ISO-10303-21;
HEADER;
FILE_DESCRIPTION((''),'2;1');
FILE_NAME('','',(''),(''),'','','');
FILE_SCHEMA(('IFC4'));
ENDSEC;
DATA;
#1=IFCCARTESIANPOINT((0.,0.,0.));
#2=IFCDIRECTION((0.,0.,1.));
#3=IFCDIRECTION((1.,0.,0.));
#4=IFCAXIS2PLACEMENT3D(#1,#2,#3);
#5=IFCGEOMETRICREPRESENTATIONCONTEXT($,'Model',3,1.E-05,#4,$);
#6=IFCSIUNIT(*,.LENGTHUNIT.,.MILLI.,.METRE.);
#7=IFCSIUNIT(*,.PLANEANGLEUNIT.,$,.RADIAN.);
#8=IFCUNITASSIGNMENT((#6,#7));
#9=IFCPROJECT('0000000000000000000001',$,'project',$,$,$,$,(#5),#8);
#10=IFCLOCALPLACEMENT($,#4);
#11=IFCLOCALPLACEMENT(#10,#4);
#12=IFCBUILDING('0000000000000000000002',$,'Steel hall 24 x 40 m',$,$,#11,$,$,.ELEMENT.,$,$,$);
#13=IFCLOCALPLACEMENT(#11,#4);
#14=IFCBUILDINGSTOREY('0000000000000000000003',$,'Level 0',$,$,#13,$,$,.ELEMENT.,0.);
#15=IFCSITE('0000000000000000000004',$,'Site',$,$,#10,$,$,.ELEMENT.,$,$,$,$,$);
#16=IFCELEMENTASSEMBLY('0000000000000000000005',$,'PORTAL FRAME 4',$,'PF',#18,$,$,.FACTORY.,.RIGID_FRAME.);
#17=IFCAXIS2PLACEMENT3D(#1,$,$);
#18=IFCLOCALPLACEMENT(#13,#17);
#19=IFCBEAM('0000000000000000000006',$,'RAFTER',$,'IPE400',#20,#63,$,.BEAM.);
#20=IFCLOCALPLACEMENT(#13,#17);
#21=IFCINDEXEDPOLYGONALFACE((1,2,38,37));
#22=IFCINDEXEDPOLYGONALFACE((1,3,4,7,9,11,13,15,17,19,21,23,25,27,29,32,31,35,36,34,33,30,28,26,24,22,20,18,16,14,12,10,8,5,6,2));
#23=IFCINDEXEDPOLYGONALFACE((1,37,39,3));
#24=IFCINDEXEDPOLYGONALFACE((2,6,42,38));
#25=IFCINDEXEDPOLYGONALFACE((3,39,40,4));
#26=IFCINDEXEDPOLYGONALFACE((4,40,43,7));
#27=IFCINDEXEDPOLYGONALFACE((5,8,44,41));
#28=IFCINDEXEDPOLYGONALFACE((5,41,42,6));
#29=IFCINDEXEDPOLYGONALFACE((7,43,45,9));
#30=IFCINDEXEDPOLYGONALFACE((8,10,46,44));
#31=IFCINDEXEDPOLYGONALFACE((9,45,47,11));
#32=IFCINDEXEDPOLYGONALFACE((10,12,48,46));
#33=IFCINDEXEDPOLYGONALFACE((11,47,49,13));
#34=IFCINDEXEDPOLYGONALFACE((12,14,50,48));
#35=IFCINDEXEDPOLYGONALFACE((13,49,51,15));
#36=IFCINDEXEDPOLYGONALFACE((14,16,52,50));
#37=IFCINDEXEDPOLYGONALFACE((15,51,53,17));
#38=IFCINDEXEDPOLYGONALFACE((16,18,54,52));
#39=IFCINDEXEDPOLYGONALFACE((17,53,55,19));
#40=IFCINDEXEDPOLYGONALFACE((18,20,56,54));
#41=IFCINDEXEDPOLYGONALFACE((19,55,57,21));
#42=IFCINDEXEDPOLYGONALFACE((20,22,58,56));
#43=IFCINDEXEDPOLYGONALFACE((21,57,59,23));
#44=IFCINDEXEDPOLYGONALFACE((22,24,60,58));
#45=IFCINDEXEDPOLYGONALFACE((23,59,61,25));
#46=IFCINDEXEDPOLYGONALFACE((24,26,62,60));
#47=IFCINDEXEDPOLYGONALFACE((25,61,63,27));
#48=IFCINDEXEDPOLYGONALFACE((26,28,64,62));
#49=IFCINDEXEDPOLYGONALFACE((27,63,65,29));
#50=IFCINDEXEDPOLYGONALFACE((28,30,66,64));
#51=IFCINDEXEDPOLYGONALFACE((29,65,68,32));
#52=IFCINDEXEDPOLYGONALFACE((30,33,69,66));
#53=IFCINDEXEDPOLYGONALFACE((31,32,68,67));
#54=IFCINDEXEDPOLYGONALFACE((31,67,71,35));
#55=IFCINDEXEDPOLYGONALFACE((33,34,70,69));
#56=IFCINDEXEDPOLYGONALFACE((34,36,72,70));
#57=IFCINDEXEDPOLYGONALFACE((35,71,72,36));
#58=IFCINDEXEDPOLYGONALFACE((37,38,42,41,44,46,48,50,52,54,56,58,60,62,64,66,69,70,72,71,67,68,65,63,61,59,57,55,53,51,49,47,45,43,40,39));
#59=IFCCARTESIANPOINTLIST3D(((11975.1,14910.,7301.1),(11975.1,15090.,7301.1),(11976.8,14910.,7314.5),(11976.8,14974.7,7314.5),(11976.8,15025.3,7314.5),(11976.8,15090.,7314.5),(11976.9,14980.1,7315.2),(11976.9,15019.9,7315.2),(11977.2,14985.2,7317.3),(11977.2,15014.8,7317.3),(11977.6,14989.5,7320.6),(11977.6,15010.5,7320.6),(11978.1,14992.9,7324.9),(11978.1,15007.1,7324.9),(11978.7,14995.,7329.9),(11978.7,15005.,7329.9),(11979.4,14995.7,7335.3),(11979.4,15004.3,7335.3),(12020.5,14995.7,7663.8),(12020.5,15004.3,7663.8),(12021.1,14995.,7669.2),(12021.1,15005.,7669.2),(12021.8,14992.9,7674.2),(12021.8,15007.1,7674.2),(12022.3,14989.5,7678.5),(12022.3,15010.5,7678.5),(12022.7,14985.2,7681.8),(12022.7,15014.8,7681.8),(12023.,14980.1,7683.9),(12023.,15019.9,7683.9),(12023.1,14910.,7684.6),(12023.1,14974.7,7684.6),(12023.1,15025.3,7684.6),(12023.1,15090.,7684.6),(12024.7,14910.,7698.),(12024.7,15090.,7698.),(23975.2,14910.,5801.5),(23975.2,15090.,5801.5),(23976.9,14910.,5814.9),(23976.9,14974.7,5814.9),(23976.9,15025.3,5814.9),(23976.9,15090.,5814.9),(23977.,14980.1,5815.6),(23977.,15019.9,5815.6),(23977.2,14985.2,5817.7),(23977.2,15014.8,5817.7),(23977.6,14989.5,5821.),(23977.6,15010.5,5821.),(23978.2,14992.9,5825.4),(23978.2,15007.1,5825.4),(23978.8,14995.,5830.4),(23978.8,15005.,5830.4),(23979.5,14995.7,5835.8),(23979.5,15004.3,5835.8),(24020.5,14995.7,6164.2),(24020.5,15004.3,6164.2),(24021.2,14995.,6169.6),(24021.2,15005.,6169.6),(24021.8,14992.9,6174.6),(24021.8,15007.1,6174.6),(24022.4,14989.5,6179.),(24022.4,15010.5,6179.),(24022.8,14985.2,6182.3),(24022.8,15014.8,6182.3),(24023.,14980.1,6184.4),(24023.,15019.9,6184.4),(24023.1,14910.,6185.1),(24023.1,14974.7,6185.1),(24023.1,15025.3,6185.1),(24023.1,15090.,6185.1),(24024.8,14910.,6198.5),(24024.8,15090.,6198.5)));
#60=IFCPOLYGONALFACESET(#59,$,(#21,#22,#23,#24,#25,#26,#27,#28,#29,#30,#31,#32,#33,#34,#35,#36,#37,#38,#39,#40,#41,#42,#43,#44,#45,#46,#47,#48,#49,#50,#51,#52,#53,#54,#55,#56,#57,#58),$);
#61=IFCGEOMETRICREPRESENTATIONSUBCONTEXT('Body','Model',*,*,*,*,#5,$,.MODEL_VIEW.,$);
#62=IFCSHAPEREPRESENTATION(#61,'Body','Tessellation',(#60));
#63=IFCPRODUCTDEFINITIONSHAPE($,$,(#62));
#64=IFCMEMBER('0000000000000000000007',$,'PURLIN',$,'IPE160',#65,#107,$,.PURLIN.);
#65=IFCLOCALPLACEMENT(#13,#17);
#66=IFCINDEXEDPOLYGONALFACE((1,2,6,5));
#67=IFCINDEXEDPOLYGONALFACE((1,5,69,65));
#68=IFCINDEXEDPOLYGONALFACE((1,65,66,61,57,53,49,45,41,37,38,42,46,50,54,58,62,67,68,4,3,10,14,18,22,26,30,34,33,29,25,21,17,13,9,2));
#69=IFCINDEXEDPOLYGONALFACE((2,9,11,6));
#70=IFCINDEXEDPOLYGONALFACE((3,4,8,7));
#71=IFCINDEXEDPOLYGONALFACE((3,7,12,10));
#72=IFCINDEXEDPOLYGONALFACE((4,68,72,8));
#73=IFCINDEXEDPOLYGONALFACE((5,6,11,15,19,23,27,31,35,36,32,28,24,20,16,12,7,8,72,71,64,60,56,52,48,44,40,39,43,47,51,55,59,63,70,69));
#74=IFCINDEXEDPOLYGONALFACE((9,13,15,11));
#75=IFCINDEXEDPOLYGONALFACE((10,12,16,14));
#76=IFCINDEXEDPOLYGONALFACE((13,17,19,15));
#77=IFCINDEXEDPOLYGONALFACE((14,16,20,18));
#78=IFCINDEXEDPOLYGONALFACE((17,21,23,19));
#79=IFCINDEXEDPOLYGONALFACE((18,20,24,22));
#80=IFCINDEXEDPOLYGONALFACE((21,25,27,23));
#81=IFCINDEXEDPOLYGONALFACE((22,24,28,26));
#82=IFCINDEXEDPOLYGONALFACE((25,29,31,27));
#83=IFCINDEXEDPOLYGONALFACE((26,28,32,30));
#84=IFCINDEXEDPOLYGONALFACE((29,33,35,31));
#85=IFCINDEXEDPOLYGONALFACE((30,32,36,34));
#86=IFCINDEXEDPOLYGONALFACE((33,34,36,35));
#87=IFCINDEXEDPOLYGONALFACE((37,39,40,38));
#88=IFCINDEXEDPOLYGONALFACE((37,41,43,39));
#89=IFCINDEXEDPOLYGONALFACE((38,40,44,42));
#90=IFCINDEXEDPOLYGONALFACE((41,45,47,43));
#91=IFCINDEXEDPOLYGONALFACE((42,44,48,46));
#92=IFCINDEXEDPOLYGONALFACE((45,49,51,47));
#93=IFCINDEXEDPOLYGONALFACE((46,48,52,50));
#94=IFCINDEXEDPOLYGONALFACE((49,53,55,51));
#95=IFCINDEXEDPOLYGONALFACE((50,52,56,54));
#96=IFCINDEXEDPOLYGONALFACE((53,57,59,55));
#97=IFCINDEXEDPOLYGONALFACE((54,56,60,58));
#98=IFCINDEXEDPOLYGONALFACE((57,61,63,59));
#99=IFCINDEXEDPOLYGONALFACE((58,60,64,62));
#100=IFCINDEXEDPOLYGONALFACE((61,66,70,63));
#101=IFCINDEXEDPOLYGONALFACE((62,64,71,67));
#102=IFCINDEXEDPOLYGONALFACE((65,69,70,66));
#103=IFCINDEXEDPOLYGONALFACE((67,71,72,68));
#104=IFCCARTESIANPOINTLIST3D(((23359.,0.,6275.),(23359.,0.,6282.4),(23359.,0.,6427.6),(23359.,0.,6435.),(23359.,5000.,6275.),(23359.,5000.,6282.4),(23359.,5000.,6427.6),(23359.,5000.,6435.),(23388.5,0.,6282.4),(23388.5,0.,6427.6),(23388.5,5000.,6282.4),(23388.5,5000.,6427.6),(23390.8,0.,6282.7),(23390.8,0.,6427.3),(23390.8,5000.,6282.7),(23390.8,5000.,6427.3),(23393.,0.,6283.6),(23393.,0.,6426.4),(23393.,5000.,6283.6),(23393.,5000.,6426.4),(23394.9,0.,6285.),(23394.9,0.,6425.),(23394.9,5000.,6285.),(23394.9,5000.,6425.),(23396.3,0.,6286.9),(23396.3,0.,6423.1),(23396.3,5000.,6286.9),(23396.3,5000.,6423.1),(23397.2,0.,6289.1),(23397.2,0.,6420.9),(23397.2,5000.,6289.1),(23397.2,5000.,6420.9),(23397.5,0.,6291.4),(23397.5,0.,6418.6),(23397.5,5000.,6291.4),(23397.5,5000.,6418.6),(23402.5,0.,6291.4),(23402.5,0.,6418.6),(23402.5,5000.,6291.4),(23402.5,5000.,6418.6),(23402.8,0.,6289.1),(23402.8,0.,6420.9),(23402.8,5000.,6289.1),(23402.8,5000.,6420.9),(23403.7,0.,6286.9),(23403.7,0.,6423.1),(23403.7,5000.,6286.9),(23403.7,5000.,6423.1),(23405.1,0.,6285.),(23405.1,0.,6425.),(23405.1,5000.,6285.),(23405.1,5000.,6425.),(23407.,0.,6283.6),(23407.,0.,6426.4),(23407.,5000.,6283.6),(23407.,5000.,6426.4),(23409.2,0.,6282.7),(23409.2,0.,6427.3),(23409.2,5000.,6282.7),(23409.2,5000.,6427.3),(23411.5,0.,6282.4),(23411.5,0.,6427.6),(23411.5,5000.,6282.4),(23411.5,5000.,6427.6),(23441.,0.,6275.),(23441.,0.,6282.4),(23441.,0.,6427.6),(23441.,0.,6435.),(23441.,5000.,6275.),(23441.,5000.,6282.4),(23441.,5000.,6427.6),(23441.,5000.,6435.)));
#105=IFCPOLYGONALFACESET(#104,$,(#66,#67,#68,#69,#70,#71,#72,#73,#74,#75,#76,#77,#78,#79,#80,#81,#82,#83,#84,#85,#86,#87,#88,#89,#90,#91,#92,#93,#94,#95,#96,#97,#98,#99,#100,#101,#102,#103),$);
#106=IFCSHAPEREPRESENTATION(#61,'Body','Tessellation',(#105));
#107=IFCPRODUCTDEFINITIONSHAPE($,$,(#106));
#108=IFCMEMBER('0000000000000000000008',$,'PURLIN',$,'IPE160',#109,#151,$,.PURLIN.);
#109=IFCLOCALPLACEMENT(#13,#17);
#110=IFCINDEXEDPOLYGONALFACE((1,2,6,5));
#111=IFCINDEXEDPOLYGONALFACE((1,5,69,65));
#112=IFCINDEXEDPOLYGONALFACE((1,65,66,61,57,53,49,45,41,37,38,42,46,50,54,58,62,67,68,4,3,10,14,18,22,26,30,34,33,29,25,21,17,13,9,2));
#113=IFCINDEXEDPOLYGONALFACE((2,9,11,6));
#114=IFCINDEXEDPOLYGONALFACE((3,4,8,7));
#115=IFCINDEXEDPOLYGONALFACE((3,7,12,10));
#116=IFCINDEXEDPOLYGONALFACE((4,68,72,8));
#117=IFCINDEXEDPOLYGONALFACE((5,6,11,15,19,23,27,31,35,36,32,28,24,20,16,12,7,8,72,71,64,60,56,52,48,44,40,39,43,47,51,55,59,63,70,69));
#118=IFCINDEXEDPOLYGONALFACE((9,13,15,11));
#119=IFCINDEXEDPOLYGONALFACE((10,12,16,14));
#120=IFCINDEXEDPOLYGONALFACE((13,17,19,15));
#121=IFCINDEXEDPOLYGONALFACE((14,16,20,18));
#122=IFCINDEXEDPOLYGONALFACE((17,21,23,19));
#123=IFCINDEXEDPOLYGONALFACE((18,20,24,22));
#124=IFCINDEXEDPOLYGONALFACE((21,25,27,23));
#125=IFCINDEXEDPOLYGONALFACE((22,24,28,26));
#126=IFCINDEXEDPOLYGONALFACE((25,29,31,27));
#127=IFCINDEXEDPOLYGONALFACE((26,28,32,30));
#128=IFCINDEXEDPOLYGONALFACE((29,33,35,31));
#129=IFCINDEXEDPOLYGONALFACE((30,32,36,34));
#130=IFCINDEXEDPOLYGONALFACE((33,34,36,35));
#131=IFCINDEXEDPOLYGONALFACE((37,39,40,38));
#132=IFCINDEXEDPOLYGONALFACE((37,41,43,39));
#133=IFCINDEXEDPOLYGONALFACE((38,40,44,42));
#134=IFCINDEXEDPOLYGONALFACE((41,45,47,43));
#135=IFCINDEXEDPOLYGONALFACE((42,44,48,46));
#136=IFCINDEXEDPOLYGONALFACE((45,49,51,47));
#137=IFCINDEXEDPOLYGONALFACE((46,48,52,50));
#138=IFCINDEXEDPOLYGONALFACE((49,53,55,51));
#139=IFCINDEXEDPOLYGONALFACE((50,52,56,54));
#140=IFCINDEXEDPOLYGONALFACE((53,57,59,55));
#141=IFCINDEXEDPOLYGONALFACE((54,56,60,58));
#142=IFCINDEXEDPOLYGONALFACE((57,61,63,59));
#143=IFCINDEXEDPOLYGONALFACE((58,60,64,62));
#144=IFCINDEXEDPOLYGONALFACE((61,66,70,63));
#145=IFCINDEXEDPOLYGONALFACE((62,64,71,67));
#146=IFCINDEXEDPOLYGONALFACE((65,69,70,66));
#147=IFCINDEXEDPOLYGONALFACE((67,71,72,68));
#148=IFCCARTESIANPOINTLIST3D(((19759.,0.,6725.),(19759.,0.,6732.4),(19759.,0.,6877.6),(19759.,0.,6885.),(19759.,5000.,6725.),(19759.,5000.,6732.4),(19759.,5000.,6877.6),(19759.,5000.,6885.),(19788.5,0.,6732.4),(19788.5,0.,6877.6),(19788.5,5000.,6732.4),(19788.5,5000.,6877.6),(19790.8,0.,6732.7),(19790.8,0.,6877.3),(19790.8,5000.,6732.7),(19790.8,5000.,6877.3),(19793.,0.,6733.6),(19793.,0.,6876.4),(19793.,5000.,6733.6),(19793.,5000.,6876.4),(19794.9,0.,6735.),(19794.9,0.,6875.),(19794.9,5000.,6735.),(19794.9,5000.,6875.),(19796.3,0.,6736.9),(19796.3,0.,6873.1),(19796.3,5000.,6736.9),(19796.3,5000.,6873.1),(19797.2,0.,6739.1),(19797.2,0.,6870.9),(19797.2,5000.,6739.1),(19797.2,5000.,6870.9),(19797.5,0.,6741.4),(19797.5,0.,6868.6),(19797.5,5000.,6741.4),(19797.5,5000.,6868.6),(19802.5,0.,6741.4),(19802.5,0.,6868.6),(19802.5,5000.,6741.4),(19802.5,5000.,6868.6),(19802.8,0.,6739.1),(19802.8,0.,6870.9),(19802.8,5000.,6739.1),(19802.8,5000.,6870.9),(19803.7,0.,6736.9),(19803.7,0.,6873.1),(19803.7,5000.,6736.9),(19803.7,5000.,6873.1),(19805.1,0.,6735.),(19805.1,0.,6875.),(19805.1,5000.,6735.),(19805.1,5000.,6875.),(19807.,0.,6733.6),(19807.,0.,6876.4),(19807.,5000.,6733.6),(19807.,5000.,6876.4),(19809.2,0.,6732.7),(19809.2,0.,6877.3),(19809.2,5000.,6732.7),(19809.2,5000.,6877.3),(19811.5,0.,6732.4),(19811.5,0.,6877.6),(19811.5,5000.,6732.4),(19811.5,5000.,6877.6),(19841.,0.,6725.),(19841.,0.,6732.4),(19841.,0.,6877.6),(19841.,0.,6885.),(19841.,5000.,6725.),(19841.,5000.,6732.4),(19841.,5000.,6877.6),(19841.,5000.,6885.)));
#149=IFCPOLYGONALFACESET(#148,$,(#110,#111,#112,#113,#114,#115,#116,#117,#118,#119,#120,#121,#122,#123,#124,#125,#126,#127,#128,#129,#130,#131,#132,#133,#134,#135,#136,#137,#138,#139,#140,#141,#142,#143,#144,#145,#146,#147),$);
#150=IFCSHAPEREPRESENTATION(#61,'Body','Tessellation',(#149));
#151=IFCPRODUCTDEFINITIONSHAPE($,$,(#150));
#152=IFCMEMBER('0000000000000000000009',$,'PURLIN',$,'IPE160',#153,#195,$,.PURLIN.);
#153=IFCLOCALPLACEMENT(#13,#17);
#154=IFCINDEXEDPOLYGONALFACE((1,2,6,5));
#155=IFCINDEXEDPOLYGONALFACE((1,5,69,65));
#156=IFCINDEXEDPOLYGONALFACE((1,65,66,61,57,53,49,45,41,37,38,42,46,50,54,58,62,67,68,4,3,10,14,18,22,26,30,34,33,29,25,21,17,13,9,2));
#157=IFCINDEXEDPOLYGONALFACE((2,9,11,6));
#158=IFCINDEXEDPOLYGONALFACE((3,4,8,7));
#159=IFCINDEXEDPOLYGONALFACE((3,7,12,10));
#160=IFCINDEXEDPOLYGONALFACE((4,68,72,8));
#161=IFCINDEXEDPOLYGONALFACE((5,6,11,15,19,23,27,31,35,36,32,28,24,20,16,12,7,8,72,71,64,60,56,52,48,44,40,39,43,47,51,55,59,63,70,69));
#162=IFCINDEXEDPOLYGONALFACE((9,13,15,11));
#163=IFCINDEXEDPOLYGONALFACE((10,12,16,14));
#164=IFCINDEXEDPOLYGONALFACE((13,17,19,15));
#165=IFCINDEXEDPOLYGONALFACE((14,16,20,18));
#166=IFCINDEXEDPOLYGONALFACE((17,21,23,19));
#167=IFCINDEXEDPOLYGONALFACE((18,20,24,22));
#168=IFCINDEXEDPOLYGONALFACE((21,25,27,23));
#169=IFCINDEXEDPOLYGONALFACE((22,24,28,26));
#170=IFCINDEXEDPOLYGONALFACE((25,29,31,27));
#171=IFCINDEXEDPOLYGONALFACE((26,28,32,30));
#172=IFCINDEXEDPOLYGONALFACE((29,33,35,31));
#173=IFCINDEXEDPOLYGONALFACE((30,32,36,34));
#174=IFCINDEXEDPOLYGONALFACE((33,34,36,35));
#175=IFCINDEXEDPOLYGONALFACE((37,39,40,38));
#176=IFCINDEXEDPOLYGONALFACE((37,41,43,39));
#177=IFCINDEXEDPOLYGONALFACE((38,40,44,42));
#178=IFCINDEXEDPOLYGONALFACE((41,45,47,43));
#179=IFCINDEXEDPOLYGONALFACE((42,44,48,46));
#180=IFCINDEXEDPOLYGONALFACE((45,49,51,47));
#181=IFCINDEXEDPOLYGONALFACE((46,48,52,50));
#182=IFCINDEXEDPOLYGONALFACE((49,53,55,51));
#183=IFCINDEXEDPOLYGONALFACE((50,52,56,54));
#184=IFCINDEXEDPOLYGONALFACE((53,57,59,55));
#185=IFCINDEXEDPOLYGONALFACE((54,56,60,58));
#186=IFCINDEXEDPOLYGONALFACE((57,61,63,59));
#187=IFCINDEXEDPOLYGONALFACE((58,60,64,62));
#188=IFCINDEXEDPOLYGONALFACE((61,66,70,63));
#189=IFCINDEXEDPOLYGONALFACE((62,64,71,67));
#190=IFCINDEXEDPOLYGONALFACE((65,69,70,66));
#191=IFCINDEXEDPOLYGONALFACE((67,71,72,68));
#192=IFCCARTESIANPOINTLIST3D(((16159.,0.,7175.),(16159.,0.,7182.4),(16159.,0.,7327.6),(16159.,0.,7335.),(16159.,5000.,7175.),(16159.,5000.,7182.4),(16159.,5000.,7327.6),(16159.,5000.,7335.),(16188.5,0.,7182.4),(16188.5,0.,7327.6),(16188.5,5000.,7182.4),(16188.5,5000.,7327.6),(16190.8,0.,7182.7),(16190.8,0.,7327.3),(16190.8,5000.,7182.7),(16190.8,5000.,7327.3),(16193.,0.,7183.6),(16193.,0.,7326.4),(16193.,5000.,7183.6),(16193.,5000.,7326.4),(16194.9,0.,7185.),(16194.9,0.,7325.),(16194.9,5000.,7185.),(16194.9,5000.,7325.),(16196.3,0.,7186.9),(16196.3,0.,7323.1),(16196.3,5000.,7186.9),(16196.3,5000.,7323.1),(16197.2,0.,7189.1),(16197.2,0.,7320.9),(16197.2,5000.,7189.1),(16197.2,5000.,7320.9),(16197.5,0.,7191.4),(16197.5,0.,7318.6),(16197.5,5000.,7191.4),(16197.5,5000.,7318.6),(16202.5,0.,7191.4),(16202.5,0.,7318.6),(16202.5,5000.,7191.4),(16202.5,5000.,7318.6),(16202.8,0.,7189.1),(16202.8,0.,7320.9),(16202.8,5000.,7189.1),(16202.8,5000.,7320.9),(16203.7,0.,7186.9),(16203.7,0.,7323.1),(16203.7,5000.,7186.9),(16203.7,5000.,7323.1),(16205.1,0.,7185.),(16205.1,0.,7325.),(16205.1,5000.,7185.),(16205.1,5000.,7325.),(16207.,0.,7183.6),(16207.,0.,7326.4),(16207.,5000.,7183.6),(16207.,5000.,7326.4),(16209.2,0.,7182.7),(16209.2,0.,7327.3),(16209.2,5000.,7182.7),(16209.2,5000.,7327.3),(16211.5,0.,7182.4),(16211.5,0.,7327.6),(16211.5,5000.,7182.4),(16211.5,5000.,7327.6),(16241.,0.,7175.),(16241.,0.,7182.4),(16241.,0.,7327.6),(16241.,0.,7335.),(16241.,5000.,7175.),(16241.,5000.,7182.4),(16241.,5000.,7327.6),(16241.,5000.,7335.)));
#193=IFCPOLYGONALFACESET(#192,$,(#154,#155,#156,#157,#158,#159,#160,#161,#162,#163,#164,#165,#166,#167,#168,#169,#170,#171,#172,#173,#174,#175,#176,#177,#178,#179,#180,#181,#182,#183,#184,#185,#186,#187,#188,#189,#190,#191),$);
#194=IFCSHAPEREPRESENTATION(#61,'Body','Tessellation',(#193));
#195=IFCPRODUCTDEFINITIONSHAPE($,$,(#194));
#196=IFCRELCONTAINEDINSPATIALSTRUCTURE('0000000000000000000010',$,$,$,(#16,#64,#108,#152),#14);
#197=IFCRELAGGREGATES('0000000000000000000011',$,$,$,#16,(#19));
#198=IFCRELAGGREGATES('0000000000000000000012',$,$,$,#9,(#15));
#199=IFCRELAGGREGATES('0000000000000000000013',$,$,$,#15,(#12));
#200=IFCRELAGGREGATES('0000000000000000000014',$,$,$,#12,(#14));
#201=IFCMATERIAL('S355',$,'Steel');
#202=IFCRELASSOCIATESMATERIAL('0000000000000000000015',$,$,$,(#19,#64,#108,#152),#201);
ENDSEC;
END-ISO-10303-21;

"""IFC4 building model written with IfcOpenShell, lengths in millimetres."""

from ifc_helpers import new_model, si_unit, frame, origin_with_axes, place, context, subcontext, project, spatial, i_section, extrude, material, element, aggregate, save


model = new_model("IFC4")

# Units and contexts
model_context = context("Model", 3, precision=1e-05, world=origin_with_axes())
body_context = subcontext(model_context, "Body", "Model", "MODEL_VIEW")
ifc_project = project(units=[si_unit("LENGTHUNIT", "METRE", prefix="MILLI"), si_unit("PLANEANGLEUNIT", "RADIAN")], contexts=[model_context])

# Site, building, storey
site_placement = place(None, origin_with_axes())
site = spatial("IfcSite", under=ifc_project, at=site_placement, Name="Site", CompositionType="ELEMENT")
building_placement = place(site_placement, origin_with_axes())
building = spatial("IfcBuilding", under=site, at=building_placement, Name="Steel hall 24 x 40 m", CompositionType="ELEMENT")
storey_placement = place(building_placement, origin_with_axes())
storey = spatial("IfcBuildingStorey", under=building, at=storey_placement, Name="Level 0", CompositionType="ELEMENT", Elevation=0.0)

# Element assembly
ifc_material = material(Name="S355", Category="Steel")
assembly_1_placement = place(storey_placement, frame((0.0, 15000.0, 0.0), z_axis=(0.0, 0.0, 1.0), x_axis=(1.0, 0.0, 0.0)))
assembly_1 = element("IfcElementAssembly", 1, at=assembly_1_placement, inside=storey, Name="PORTAL FRAME 4", ObjectType="PF", AssemblyPlace="FACTORY", PredefinedType="RIGID_FRAME")

# Beam
beam_1_placement = place(storey_placement, frame((24000.0, 15000.0, 6000.0), z_axis=(-0.9923, 0.0, 0.124), x_axis=(0.0, 1.0, 0.0)))
beam_1 = element("IfcBeam", 2, at=beam_1_placement, material=ifc_material, Name="RAFTER", ObjectType="IPE400", PredefinedType="BEAM", context=body_context, shape_type="SweptSolid", body=[
    extrude(i_section(OverallWidth=180.0, OverallDepth=400.0, WebThickness=8.6, FlangeThickness=13.5, FilletRadius=21.0), origin_with_axes(), (0.0, 0.0, 1.0), 12093.4),
])

# Members
for number, where, z_axis, x_axis, name in (
    (3, (23400.0, 0.0, 6355.0), (0.0, 1.0, 0.0), (1.0, 0.0, 0.0), "PURLIN"),
    (4, (19800.0, 0.0, 6805.0), (0.0, 1.0, 0.0), (1.0, 0.0, 0.0), "PURLIN"),
    (5, (16200.0, 0.0, 7255.0), (0.0, 1.0, 0.0), (1.0, 0.0, 0.0), "PURLIN"),
):
    element("IfcMember", number, at=place(storey_placement, frame(where, z_axis=z_axis, x_axis=x_axis)), inside=storey, material=ifc_material, Name=name, ObjectType="IPE160", PredefinedType="PURLIN", context=body_context, shape_type="SweptSolid", body=[
        extrude(i_section(OverallWidth=82.0, OverallDepth=160.0, WebThickness=5.0, FlangeThickness=7.4, FilletRadius=9.0), origin_with_axes(), (0.0, 0.0, 1.0), 5000.0),
    ])

aggregate(assembly_1, [beam_1])

save(model, "model.ifc")
